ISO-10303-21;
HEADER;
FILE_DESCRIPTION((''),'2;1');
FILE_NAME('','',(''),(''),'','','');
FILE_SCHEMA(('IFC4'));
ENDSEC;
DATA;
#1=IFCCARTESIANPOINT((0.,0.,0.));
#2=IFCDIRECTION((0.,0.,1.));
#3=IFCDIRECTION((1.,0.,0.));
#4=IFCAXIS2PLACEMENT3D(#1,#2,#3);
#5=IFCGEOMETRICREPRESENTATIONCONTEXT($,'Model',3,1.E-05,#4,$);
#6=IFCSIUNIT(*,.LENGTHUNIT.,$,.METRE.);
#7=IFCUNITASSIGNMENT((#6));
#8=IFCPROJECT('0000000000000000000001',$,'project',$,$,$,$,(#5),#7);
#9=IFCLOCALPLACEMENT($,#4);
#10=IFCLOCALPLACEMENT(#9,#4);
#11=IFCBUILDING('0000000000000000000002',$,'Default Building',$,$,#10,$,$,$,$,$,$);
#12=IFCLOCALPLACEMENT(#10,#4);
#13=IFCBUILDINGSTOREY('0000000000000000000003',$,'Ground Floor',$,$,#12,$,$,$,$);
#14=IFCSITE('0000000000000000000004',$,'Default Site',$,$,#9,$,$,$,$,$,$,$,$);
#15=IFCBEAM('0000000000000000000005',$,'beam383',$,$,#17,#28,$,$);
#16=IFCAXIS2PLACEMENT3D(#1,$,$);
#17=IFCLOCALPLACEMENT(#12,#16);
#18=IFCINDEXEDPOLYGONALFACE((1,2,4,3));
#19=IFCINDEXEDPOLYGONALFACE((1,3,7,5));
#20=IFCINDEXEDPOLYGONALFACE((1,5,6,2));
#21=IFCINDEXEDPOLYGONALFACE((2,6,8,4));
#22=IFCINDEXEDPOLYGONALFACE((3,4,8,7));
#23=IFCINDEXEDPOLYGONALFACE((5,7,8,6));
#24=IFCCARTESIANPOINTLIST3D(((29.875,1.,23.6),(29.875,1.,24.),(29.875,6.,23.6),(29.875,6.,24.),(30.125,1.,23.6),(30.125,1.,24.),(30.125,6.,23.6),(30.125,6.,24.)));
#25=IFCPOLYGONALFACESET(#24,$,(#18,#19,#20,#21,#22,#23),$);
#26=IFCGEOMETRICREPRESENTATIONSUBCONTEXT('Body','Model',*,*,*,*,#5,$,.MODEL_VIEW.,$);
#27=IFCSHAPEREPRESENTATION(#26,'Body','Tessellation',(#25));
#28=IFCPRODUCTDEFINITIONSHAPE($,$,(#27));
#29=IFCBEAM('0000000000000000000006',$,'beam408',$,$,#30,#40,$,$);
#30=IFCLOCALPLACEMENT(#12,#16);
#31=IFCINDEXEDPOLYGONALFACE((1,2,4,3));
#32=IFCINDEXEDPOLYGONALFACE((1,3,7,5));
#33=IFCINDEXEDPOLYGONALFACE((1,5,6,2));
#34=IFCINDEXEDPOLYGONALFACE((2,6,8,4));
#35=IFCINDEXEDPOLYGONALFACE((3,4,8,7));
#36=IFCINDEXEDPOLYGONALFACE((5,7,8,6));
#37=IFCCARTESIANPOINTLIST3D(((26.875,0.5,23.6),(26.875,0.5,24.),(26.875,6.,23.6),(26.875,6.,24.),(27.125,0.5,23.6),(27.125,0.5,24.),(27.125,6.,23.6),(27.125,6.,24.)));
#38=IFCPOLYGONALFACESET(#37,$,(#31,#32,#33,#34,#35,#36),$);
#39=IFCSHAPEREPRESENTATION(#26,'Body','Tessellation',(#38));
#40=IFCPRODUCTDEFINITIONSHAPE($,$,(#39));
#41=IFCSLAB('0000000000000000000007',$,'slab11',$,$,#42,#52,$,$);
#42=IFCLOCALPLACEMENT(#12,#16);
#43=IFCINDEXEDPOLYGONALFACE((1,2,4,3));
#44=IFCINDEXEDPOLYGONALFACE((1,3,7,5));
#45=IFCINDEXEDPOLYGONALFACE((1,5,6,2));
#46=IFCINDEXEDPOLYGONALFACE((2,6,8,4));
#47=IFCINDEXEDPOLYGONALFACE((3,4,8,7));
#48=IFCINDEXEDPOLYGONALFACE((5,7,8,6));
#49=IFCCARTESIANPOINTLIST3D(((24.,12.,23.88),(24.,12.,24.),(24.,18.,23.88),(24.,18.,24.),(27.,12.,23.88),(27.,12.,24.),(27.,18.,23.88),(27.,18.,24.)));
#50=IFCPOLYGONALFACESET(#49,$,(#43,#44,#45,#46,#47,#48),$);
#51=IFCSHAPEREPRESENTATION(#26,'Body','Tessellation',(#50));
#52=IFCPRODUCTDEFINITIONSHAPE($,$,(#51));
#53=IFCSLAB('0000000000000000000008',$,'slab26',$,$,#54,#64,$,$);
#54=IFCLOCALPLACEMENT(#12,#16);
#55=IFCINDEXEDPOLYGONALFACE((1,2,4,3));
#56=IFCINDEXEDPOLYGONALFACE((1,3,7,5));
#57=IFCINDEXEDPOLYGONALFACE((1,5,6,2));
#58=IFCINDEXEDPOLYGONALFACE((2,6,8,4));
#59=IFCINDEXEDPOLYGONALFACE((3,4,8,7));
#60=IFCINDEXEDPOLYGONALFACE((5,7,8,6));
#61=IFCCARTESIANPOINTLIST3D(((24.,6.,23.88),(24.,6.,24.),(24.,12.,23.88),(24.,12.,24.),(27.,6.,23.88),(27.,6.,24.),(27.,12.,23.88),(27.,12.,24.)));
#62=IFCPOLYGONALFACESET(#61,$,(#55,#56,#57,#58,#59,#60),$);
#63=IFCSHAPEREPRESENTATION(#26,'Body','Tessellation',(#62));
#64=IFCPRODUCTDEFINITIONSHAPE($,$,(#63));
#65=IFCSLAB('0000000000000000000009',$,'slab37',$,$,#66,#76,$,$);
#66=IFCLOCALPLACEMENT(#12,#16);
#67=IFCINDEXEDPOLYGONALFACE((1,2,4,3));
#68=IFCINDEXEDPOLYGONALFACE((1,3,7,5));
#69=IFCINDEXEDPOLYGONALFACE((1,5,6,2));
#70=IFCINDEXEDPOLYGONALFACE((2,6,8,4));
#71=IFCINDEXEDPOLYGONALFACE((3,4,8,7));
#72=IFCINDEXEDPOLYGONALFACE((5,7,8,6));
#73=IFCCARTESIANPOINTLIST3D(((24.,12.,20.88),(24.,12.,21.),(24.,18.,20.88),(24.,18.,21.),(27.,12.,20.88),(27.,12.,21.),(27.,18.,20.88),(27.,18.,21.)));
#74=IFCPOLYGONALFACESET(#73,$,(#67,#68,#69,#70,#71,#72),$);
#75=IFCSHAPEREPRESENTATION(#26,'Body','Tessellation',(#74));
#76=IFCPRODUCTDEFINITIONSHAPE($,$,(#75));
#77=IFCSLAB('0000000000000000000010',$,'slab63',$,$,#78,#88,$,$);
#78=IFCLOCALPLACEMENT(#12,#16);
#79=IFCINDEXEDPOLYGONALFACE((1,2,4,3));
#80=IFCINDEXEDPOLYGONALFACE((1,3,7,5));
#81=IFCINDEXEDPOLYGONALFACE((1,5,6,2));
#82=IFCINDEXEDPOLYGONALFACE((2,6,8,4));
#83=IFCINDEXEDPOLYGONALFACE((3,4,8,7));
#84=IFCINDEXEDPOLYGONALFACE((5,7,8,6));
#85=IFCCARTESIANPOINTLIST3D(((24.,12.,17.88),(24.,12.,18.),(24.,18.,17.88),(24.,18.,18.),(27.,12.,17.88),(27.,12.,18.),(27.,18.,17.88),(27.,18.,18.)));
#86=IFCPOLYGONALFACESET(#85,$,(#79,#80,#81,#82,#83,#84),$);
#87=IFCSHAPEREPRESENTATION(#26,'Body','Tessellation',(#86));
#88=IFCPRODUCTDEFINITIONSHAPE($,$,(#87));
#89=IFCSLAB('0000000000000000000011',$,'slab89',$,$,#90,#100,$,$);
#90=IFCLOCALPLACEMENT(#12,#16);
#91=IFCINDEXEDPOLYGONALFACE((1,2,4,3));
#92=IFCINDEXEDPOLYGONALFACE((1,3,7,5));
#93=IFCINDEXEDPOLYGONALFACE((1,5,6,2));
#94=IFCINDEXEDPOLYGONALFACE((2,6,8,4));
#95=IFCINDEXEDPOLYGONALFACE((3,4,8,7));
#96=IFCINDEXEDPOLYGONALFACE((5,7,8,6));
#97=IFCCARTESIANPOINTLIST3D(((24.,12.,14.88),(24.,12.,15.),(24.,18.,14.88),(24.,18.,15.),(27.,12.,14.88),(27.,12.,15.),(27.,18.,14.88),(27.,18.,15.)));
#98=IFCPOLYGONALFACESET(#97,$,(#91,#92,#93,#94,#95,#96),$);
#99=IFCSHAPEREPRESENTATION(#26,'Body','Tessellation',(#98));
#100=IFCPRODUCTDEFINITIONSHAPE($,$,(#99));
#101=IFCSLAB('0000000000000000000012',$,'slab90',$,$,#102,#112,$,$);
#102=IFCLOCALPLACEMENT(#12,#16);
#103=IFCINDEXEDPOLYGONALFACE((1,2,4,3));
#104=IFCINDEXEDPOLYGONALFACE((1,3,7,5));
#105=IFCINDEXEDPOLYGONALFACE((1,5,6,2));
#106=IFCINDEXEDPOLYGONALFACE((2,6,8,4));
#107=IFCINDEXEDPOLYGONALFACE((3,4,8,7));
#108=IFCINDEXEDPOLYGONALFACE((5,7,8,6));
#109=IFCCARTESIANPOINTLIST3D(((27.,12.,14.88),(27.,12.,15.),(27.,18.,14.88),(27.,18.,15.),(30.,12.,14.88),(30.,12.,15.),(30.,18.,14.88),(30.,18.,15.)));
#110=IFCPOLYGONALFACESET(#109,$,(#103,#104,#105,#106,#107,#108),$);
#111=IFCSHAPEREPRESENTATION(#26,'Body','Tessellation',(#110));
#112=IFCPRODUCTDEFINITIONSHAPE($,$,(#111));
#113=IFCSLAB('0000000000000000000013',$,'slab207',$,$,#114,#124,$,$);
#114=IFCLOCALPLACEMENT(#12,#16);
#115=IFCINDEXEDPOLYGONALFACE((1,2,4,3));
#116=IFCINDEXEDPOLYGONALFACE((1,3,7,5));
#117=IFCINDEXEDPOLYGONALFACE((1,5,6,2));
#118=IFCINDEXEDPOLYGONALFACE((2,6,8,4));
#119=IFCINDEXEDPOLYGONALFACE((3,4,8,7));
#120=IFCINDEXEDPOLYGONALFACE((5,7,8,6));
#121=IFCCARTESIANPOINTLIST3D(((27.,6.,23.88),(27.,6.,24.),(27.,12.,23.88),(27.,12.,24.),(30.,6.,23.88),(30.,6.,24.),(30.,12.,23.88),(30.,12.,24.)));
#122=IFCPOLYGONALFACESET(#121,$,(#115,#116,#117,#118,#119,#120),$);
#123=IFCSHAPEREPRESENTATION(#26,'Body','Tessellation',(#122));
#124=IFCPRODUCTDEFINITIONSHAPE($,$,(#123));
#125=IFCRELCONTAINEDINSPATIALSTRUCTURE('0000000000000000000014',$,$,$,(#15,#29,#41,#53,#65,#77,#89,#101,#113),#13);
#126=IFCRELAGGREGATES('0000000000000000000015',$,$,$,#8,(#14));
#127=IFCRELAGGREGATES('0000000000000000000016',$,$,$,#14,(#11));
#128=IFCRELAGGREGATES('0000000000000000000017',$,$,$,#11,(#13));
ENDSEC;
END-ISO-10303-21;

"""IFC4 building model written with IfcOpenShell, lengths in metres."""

from ifc_helpers import new_model, si_unit, frame, origin_with_axes, place, context, subcontext, project, spatial, indexed_curve, outline, extrude, element, save


model = new_model("IFC4")

# Units and contexts
model_context = context("Model", 3, precision=1e-05, world=origin_with_axes())
body_context = subcontext(model_context, "Body", "Model", "MODEL_VIEW")
ifc_project = project(units=[si_unit("LENGTHUNIT", "METRE")], contexts=[model_context])

# Site, building, storey
site_placement = place(None, origin_with_axes())
site = spatial("IfcSite", under=ifc_project, at=site_placement, Name="Default Site")
building_placement = place(site_placement, origin_with_axes())
building = spatial("IfcBuilding", under=site, at=building_placement, Name="Default Building")
storey_placement = place(building_placement, origin_with_axes())
storey = spatial("IfcBuildingStorey", under=building, at=storey_placement, Name="Ground Floor")

# Beams
beam_1_placement = place(storey_placement, frame((29.875, 6.0, 23.6), z_axis=(0.0, 0.0, 1.0), x_axis=(0.0, -1.0, 0.0)))
element("IfcBeam", 1, at=beam_1_placement, inside=storey, Name="beam383", context=body_context, shape_type="SweptSolid", body=[
    extrude(outline(indexed_curve([(0.0, 0.0), (0.0, 0.25), (5.0, 0.25), (5.0, 0.0), (0.0, 0.0)], self_intersect=False)), origin_with_axes(), (0.0, 0.0, 1.0), 0.4),
])
beam_2_placement = place(storey_placement, frame((26.875, 6.0, 23.6), z_axis=(0.0, 0.0, 1.0), x_axis=(0.0, -1.0, 0.0)))
element("IfcBeam", 2, at=beam_2_placement, inside=storey, Name="beam408", context=body_context, shape_type="SweptSolid", body=[
    extrude(outline(indexed_curve([(0.0, 0.0), (0.0, 0.25), (5.5, 0.25), (5.5, 0.0), (0.0, 0.0)], self_intersect=False)), origin_with_axes(), (0.0, 0.0, 1.0), 0.4),
])

# Slabs
for number, where, z_axis, x_axis, name in (
    (3, (24.0, 12.0, 23.88), (0.0, 0.0, 1.0), (1.0, 0.0, 0.0), "slab11"),
    (4, (24.0, 6.0, 23.88), (0.0, 0.0, 1.0), (1.0, 0.0, 0.0), "slab26"),
    (5, (24.0, 12.0, 20.88), (0.0, 0.0, 1.0), (1.0, 0.0, 0.0), "slab37"),
    (6, (24.0, 12.0, 17.88), (0.0, 0.0, 1.0), (1.0, 0.0, 0.0), "slab63"),
    (7, (24.0, 12.0, 14.88), (0.0, 0.0, 1.0), (1.0, 0.0, 0.0), "slab89"),
    (8, (27.0, 12.0, 14.88), (0.0, 0.0, 1.0), (1.0, 0.0, 0.0), "slab90"),
    (9, (27.0, 6.0, 23.88), (0.0, 0.0, 1.0), (1.0, 0.0, 0.0), "slab207"),
):
    element("IfcSlab", number, at=place(storey_placement, frame(where, z_axis=z_axis, x_axis=x_axis)), inside=storey, Name=name, context=body_context, shape_type="SweptSolid", body=[
        extrude(outline(indexed_curve([(0.0, 0.0), (0.0, 6.0), (3.0, 6.0), (3.0, 0.0), (0.0, 0.0)], self_intersect=False)), origin_with_axes(), (0.0, 0.0, 1.0), 0.12),
    ])

save(model, "model.ifc")
